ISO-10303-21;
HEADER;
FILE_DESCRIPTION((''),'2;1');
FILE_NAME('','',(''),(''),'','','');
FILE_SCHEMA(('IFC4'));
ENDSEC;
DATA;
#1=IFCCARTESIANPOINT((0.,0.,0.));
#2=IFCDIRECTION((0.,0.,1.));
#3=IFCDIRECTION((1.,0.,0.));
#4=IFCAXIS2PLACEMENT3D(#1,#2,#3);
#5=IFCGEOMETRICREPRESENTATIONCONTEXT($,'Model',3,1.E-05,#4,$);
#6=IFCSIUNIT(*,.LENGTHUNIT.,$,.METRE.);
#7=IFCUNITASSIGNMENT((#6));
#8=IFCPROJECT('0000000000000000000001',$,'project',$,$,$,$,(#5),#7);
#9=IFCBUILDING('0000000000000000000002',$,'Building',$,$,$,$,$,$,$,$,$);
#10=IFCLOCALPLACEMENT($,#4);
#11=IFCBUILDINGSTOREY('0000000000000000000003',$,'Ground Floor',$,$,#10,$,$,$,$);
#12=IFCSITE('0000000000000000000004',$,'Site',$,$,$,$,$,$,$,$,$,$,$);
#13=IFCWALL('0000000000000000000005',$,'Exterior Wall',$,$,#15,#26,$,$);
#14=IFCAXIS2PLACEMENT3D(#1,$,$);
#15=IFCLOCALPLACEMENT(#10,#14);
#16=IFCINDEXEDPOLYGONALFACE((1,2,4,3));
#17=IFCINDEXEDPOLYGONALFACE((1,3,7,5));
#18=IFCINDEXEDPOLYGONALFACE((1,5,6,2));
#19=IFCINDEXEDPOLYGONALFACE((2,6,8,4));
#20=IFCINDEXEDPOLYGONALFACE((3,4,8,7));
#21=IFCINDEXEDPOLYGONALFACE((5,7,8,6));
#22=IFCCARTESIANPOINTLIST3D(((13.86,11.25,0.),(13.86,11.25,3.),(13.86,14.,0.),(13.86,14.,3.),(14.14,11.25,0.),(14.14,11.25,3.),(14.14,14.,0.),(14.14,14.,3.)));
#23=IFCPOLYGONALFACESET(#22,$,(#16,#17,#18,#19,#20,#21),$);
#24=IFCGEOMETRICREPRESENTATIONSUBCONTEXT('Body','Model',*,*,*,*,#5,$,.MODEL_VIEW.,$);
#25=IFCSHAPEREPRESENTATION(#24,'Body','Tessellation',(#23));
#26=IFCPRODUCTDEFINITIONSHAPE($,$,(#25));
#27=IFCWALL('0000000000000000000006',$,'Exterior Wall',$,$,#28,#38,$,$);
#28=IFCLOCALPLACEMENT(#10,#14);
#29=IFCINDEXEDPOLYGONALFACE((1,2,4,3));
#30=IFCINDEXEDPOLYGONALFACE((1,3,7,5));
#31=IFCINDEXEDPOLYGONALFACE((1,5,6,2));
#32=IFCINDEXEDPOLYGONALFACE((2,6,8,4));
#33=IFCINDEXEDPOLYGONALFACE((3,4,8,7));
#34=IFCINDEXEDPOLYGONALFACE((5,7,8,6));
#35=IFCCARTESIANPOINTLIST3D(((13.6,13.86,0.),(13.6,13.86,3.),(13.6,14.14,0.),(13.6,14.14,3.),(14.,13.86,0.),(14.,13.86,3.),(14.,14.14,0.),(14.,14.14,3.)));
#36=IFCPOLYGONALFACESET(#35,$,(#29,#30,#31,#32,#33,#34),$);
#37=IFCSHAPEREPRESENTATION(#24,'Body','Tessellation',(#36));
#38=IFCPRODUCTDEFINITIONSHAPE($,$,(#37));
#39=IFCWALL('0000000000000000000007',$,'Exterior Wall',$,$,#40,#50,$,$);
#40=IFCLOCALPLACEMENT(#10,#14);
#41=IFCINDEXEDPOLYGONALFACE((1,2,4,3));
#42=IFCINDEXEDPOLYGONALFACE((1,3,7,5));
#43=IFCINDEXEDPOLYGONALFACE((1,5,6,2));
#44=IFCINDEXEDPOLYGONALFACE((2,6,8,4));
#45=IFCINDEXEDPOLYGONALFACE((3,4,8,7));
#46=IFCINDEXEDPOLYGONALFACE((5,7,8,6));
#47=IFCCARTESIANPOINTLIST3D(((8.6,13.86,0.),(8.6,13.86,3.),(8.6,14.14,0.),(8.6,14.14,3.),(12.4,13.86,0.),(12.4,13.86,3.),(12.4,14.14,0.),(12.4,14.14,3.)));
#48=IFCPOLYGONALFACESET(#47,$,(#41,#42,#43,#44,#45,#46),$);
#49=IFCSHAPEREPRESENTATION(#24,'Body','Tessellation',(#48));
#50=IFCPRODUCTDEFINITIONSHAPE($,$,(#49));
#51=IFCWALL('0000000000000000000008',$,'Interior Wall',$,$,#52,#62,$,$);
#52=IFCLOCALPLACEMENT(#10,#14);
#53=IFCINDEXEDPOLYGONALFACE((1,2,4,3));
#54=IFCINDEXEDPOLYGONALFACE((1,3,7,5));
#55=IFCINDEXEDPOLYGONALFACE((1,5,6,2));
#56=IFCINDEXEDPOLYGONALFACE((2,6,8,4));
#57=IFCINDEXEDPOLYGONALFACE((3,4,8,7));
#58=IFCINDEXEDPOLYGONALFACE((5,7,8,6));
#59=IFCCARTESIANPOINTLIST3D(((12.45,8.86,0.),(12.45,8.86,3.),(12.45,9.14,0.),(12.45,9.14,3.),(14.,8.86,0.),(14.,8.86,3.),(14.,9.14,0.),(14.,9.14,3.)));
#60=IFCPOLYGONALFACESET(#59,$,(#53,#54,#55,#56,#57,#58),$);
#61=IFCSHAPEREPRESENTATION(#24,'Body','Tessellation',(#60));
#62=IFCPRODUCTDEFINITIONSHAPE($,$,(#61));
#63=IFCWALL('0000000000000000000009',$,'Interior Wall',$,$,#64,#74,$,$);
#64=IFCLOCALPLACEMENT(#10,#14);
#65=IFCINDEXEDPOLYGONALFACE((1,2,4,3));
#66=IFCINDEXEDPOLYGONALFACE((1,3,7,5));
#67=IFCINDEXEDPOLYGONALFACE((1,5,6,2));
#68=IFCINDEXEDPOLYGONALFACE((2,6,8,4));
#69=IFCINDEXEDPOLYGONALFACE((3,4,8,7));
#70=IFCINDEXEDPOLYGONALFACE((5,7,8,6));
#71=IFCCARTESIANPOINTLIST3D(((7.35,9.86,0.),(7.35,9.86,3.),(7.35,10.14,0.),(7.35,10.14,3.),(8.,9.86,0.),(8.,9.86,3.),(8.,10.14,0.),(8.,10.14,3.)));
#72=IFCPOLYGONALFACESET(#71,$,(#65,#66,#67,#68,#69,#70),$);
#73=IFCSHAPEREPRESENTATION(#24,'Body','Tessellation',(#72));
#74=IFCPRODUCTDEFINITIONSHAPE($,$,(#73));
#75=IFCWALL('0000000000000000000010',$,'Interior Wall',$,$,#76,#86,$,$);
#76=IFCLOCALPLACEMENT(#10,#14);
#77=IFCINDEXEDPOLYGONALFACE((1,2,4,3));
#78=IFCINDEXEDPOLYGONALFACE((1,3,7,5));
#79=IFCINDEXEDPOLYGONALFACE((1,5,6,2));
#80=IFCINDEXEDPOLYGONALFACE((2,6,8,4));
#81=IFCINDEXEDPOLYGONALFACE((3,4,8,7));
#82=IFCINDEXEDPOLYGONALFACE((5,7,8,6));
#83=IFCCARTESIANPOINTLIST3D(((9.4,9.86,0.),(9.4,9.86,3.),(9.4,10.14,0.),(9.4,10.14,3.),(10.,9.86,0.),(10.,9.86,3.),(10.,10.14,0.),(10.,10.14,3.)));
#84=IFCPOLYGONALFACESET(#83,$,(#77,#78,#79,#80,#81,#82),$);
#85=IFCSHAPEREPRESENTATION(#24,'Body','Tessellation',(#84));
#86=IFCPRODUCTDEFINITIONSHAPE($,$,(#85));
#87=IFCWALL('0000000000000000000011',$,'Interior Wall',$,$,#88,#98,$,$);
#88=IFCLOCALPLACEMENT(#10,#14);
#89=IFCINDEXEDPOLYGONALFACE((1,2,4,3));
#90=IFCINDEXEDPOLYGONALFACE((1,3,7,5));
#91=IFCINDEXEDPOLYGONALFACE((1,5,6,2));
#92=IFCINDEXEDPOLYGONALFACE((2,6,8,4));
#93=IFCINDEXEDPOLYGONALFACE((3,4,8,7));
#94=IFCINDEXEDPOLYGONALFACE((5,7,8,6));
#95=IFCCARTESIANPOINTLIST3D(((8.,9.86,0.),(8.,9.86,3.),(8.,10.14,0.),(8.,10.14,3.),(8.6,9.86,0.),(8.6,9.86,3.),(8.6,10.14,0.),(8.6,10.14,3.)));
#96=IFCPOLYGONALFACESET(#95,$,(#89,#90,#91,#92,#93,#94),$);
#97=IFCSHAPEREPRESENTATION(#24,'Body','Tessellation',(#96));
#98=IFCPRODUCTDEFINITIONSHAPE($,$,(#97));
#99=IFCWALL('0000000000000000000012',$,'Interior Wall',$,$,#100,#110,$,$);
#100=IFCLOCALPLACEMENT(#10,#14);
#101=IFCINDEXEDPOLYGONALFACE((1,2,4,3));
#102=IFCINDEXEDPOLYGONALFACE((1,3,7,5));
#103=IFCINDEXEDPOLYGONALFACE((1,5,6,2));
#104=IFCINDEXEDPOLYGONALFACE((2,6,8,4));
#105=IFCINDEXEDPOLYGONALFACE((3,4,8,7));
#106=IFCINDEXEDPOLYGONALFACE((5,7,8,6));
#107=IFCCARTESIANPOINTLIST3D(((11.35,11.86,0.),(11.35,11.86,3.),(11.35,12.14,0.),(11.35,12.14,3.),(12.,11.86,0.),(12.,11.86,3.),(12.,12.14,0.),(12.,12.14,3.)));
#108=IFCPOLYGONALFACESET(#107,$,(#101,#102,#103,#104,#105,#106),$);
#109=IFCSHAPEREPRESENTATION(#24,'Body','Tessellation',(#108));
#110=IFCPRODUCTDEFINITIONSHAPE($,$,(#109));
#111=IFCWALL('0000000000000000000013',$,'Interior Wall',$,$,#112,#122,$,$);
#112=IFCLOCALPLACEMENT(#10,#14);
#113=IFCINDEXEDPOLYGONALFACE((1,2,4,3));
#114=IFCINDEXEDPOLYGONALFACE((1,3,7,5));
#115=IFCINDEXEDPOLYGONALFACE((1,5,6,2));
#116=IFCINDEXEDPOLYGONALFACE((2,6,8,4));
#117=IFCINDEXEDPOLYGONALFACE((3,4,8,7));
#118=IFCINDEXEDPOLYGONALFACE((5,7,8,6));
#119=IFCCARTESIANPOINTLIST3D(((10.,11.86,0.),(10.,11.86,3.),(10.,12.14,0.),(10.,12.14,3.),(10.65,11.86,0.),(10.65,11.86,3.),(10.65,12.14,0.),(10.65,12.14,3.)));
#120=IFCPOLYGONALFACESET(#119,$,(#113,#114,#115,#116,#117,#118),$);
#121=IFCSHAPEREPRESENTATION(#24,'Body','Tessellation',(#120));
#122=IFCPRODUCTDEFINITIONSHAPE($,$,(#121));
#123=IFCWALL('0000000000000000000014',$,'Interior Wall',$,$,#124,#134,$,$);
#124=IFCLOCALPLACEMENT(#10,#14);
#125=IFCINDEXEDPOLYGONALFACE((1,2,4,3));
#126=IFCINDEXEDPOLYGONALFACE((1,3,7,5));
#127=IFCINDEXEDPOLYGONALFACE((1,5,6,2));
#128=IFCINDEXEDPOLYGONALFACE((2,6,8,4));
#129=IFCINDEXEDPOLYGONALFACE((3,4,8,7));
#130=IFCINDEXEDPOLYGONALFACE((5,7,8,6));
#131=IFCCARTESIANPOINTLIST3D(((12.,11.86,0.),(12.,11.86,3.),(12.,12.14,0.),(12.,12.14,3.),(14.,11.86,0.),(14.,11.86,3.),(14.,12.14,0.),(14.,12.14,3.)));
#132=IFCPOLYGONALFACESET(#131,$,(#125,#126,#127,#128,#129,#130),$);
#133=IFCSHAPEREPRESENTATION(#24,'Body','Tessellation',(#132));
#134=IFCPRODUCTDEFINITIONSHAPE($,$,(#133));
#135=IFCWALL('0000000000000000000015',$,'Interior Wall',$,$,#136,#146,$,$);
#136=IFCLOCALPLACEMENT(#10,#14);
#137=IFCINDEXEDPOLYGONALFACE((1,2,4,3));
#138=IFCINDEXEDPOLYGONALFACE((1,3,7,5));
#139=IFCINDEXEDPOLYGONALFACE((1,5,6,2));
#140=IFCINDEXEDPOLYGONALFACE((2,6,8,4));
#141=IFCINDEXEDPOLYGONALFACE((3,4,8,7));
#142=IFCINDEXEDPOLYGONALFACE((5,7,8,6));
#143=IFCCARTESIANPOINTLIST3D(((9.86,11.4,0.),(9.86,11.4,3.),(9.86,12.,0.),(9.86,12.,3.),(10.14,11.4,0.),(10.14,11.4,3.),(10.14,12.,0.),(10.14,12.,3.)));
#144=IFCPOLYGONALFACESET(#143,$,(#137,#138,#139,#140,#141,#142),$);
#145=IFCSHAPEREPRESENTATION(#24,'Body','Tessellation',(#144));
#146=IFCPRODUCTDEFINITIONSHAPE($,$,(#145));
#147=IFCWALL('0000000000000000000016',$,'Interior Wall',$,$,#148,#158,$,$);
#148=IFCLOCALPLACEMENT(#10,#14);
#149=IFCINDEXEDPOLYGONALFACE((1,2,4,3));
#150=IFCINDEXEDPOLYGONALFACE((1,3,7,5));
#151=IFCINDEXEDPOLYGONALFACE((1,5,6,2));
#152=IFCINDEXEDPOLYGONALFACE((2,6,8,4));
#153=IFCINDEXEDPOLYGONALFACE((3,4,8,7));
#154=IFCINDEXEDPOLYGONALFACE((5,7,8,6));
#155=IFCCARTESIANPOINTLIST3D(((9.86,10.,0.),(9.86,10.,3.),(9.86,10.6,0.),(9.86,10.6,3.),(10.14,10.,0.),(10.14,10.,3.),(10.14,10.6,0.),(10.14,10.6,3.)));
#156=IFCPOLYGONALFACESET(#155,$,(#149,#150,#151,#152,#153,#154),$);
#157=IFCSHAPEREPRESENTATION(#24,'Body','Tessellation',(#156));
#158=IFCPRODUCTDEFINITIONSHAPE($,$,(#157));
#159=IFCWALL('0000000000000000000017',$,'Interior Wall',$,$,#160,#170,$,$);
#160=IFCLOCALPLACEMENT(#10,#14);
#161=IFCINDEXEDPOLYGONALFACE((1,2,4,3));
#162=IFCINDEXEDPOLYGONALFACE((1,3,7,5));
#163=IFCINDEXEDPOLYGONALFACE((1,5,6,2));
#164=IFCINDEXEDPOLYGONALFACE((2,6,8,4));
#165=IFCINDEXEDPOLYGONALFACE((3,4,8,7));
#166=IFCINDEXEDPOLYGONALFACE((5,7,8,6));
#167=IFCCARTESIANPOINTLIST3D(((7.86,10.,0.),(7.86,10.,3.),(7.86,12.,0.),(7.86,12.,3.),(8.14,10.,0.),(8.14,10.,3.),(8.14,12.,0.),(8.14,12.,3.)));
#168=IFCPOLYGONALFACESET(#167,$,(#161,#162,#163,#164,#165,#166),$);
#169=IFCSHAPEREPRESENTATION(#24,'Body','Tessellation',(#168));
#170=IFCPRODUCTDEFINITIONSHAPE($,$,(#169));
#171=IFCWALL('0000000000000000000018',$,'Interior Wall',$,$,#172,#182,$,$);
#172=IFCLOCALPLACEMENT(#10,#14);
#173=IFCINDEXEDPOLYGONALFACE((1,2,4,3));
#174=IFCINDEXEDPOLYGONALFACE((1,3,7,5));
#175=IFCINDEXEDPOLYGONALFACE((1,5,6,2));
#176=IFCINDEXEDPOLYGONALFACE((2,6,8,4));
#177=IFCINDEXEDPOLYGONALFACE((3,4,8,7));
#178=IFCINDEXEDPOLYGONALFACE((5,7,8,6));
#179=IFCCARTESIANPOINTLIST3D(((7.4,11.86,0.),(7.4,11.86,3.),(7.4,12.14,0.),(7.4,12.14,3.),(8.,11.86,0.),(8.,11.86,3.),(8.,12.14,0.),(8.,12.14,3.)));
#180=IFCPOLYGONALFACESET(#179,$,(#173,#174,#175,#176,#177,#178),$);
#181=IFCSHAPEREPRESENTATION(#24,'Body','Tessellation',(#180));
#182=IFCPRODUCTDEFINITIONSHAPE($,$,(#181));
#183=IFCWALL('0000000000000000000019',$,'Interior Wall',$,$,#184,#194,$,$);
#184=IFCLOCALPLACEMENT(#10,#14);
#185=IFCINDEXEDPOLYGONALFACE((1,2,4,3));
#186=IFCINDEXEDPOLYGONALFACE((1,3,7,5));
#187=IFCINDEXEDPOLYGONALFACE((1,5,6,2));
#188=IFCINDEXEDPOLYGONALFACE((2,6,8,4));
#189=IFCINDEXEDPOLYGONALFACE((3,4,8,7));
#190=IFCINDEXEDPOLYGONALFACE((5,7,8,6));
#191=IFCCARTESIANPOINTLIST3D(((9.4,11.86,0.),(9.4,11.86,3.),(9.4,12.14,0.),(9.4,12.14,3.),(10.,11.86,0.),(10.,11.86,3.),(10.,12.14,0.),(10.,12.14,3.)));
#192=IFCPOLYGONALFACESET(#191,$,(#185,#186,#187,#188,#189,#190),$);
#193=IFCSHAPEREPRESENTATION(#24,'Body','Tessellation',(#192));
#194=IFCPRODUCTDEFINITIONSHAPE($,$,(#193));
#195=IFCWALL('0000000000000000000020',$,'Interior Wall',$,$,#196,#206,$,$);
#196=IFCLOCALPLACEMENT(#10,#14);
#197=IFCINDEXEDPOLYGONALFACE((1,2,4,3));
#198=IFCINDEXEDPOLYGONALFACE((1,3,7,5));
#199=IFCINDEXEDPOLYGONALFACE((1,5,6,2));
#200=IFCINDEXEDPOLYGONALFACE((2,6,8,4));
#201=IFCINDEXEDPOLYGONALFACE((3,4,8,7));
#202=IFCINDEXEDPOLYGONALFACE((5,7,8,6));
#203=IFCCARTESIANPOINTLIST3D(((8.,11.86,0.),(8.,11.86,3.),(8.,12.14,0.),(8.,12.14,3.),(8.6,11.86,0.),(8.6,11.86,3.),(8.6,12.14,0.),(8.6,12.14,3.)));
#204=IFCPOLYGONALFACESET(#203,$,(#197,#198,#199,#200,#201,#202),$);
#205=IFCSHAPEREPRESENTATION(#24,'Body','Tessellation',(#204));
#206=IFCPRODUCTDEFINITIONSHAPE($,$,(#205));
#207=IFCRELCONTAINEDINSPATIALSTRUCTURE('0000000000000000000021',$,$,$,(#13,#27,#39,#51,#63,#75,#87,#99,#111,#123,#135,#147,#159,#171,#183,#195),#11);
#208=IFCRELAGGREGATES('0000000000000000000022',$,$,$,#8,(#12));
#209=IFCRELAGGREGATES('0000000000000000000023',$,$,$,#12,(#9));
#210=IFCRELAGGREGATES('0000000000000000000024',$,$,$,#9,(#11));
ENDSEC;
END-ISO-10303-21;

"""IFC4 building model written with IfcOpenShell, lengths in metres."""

from ifc_helpers import new_model, si_unit, frame, origin_with_axes, place, context, subcontext, project, spatial, indexed_curve, outline, extrude, element, save


model = new_model("IFC4")

# Units and contexts
model_context = context("Model", 3, precision=1e-05, world=origin_with_axes())
body_context = subcontext(model_context, "Body", "Model", "MODEL_VIEW")
ifc_project = project(units=[si_unit("LENGTHUNIT", "METRE")], contexts=[model_context])

# Site, building, storey
site = spatial("IfcSite", under=ifc_project, Name="Site")
building = spatial("IfcBuilding", under=site, Name="Building")
storey_placement = place(None, origin_with_axes())
storey = spatial("IfcBuildingStorey", under=building, at=storey_placement, Name="Ground Floor")

# Walls
wall_1_placement = place(storey_placement, frame((14.0, 11.25, 0.0), z_axis=(0.0, 0.0, 1.0), x_axis=(0.0, 1.0, 0.0)))
element("IfcWall", 1, at=wall_1_placement, inside=storey, Name="Exterior Wall", context=body_context, shape_type="SweptSolid", body=[
    extrude(outline(indexed_curve([(0.0, 0.0), (0.0, 0.28), (2.75, 0.28), (2.75, 0.0), (0.0, 0.0)], self_intersect=False)), frame((0.0, -0.14, 0.0), z_axis=(0.0, 0.0, 1.0), x_axis=(1.0, 0.0, 0.0)), (0.0, 0.0, 1.0), 3.0),
])
wall_2_placement = place(storey_placement, frame((14.0, 14.0, 0.0), z_axis=(0.0, 0.0, 1.0), x_axis=(-1.0, 0.0, 0.0)))
element("IfcWall", 2, at=wall_2_placement, inside=storey, Name="Exterior Wall", context=body_context, shape_type="SweptSolid", body=[
    extrude(outline(indexed_curve([(0.0, 0.0), (0.0, 0.28), (0.4, 0.28), (0.4, 0.0), (0.0, 0.0)], self_intersect=False)), frame((0.0, -0.14, 0.0), z_axis=(0.0, 0.0, 1.0), x_axis=(1.0, 0.0, 0.0)), (0.0, 0.0, 1.0), 3.0),
])
wall_3_placement = place(storey_placement, frame((12.4, 14.0, 0.0), z_axis=(0.0, 0.0, 1.0), x_axis=(-1.0, 0.0, 0.0)))
element("IfcWall", 3, at=wall_3_placement, inside=storey, Name="Exterior Wall", context=body_context, shape_type="SweptSolid", body=[
    extrude(outline(indexed_curve([(0.0, 0.0), (0.0, 0.28), (3.8, 0.28), (3.8, 0.0), (0.0, 0.0)], self_intersect=False)), frame((0.0, -0.14, 0.0), z_axis=(0.0, 0.0, 1.0), x_axis=(1.0, 0.0, 0.0)), (0.0, 0.0, 1.0), 3.0),
])
wall_4_placement = place(storey_placement, frame((14.0, 9.0, 0.0), z_axis=(0.0, 0.0, 1.0), x_axis=(-1.0, 0.0, 0.0)))
element("IfcWall", 4, at=wall_4_placement, inside=storey, Name="Interior Wall", context=body_context, shape_type="SweptSolid", body=[
    extrude(outline(indexed_curve([(0.0, 0.0), (0.0, 0.28), (1.55, 0.28), (1.55, 0.0), (0.0, 0.0)], self_intersect=False)), frame((0.0, -0.14, 0.0), z_axis=(0.0, 0.0, 1.0), x_axis=(1.0, 0.0, 0.0)), (0.0, 0.0, 1.0), 3.0),
])
wall_5_placement = place(storey_placement, frame((8.0, 10.0, 0.0), z_axis=(0.0, 0.0, 1.0), x_axis=(-1.0, 0.0, 0.0)))
element("IfcWall", 5, at=wall_5_placement, inside=storey, Name="Interior Wall", context=body_context, shape_type="SweptSolid", body=[
    extrude(outline(indexed_curve([(0.0, 0.0), (0.0, 0.28), (0.65, 0.28), (0.65, 0.0), (0.0, 0.0)], self_intersect=False)), frame((0.0, -0.14, 0.0), z_axis=(0.0, 0.0, 1.0), x_axis=(1.0, 0.0, 0.0)), (0.0, 0.0, 1.0), 3.0),
])
for number, where, z_axis, x_axis, name in (
    (6, (10.0, 10.0, 0.0), (0.0, 0.0, 1.0), (-1.0, 0.0, 0.0), "Interior Wall"),
    (7, (8.6, 10.0, 0.0), (0.0, 0.0, 1.0), (-1.0, 0.0, 0.0), "Interior Wall"),
):
    element("IfcWall", number, at=place(storey_placement, frame(where, z_axis=z_axis, x_axis=x_axis)), inside=storey, Name=name, context=body_context, shape_type="SweptSolid", body=[
        extrude(outline(indexed_curve([(0.0, 0.0), (0.0, 0.28), (0.6, 0.28), (0.6, 0.0), (0.0, 0.0)], self_intersect=False)), frame((0.0, -0.14, 0.0), z_axis=(0.0, 0.0, 1.0), x_axis=(1.0, 0.0, 0.0)), (0.0, 0.0, 1.0), 3.0),
    ])
for number, where, z_axis, x_axis, name in (
    (8, (12.0, 12.0, 0.0), (0.0, 0.0, 1.0), (-1.0, 0.0, 0.0), "Interior Wall"),
    (9, (10.65, 12.0, 0.0), (0.0, 0.0, 1.0), (-1.0, 0.0, 0.0), "Interior Wall"),
):
    element("IfcWall", number, at=place(storey_placement, frame(where, z_axis=z_axis, x_axis=x_axis)), inside=storey, Name=name, context=body_context, shape_type="SweptSolid", body=[
        extrude(outline(indexed_curve([(0.0, 0.0), (0.0, 0.28), (0.65, 0.28), (0.65, 0.0), (0.0, 0.0)], self_intersect=False)), frame((0.0, -0.14, 0.0), z_axis=(0.0, 0.0, 1.0), x_axis=(1.0, 0.0, 0.0)), (0.0, 0.0, 1.0), 3.0),
    ])
wall_6_placement = place(storey_placement, frame((14.0, 12.0, 0.0), z_axis=(0.0, 0.0, 1.0), x_axis=(-1.0, 0.0, 0.0)))
element("IfcWall", 10, at=wall_6_placement, inside=storey, Name="Interior Wall", context=body_context, shape_type="SweptSolid", body=[
    extrude(outline(indexed_curve([(0.0, 0.0), (0.0, 0.28), (2.0, 0.28), (2.0, 0.0), (0.0, 0.0)], self_intersect=False)), frame((0.0, -0.14, 0.0), z_axis=(0.0, 0.0, 1.0), x_axis=(1.0, 0.0, 0.0)), (0.0, 0.0, 1.0), 3.0),
])
for number, where, z_axis, x_axis, name in (
    (11, (10.0, 12.0, 0.0), (0.0, 0.0, 1.0), (0.0, -1.0, 0.0), "Interior Wall"),
    (12, (10.0, 10.6, 0.0), (0.0, 0.0, 1.0), (0.0, -1.0, 0.0), "Interior Wall"),
):
    element("IfcWall", number, at=place(storey_placement, frame(where, z_axis=z_axis, x_axis=x_axis)), inside=storey, Name=name, context=body_context, shape_type="SweptSolid", body=[
        extrude(outline(indexed_curve([(0.0, 0.0), (0.0, 0.28), (0.6, 0.28), (0.6, 0.0), (0.0, 0.0)], self_intersect=False)), frame((0.0, -0.14, 0.0), z_axis=(0.0, 0.0, 1.0), x_axis=(1.0, 0.0, 0.0)), (0.0, 0.0, 1.0), 3.0),
    ])
wall_7_placement = place(storey_placement, frame((8.0, 10.0, 0.0), z_axis=(0.0, 0.0, 1.0), x_axis=(0.0, 1.0, 0.0)))
element("IfcWall", 13, at=wall_7_placement, inside=storey, Name="Interior Wall", context=body_context, shape_type="SweptSolid", body=[
    extrude(outline(indexed_curve([(0.0, 0.0), (0.0, 0.28), (2.0, 0.28), (2.0, 0.0), (0.0, 0.0)], self_intersect=False)), frame((0.0, -0.14, 0.0), z_axis=(0.0, 0.0, 1.0), x_axis=(1.0, 0.0, 0.0)), (0.0, 0.0, 1.0), 3.0),
])
for number, where, z_axis, x_axis, name in (
    (14, (8.0, 12.0, 0.0), (0.0, 0.0, 1.0), (-1.0, 0.0, 0.0), "Interior Wall"),
    (15, (10.0, 12.0, 0.0), (0.0, 0.0, 1.0), (-1.0, 0.0, 0.0), "Interior Wall"),
    (16, (8.6, 12.0, 0.0), (0.0, 0.0, 1.0), (-1.0, 0.0, 0.0), "Interior Wall"),
):
    element("IfcWall", number, at=place(storey_placement, frame(where, z_axis=z_axis, x_axis=x_axis)), inside=storey, Name=name, context=body_context, shape_type="SweptSolid", body=[
        extrude(outline(indexed_curve([(0.0, 0.0), (0.0, 0.28), (0.6, 0.28), (0.6, 0.0), (0.0, 0.0)], self_intersect=False)), frame((0.0, -0.14, 0.0), z_axis=(0.0, 0.0, 1.0), x_axis=(1.0, 0.0, 0.0)), (0.0, 0.0, 1.0), 3.0),
    ])

save(model, "model.ifc")
